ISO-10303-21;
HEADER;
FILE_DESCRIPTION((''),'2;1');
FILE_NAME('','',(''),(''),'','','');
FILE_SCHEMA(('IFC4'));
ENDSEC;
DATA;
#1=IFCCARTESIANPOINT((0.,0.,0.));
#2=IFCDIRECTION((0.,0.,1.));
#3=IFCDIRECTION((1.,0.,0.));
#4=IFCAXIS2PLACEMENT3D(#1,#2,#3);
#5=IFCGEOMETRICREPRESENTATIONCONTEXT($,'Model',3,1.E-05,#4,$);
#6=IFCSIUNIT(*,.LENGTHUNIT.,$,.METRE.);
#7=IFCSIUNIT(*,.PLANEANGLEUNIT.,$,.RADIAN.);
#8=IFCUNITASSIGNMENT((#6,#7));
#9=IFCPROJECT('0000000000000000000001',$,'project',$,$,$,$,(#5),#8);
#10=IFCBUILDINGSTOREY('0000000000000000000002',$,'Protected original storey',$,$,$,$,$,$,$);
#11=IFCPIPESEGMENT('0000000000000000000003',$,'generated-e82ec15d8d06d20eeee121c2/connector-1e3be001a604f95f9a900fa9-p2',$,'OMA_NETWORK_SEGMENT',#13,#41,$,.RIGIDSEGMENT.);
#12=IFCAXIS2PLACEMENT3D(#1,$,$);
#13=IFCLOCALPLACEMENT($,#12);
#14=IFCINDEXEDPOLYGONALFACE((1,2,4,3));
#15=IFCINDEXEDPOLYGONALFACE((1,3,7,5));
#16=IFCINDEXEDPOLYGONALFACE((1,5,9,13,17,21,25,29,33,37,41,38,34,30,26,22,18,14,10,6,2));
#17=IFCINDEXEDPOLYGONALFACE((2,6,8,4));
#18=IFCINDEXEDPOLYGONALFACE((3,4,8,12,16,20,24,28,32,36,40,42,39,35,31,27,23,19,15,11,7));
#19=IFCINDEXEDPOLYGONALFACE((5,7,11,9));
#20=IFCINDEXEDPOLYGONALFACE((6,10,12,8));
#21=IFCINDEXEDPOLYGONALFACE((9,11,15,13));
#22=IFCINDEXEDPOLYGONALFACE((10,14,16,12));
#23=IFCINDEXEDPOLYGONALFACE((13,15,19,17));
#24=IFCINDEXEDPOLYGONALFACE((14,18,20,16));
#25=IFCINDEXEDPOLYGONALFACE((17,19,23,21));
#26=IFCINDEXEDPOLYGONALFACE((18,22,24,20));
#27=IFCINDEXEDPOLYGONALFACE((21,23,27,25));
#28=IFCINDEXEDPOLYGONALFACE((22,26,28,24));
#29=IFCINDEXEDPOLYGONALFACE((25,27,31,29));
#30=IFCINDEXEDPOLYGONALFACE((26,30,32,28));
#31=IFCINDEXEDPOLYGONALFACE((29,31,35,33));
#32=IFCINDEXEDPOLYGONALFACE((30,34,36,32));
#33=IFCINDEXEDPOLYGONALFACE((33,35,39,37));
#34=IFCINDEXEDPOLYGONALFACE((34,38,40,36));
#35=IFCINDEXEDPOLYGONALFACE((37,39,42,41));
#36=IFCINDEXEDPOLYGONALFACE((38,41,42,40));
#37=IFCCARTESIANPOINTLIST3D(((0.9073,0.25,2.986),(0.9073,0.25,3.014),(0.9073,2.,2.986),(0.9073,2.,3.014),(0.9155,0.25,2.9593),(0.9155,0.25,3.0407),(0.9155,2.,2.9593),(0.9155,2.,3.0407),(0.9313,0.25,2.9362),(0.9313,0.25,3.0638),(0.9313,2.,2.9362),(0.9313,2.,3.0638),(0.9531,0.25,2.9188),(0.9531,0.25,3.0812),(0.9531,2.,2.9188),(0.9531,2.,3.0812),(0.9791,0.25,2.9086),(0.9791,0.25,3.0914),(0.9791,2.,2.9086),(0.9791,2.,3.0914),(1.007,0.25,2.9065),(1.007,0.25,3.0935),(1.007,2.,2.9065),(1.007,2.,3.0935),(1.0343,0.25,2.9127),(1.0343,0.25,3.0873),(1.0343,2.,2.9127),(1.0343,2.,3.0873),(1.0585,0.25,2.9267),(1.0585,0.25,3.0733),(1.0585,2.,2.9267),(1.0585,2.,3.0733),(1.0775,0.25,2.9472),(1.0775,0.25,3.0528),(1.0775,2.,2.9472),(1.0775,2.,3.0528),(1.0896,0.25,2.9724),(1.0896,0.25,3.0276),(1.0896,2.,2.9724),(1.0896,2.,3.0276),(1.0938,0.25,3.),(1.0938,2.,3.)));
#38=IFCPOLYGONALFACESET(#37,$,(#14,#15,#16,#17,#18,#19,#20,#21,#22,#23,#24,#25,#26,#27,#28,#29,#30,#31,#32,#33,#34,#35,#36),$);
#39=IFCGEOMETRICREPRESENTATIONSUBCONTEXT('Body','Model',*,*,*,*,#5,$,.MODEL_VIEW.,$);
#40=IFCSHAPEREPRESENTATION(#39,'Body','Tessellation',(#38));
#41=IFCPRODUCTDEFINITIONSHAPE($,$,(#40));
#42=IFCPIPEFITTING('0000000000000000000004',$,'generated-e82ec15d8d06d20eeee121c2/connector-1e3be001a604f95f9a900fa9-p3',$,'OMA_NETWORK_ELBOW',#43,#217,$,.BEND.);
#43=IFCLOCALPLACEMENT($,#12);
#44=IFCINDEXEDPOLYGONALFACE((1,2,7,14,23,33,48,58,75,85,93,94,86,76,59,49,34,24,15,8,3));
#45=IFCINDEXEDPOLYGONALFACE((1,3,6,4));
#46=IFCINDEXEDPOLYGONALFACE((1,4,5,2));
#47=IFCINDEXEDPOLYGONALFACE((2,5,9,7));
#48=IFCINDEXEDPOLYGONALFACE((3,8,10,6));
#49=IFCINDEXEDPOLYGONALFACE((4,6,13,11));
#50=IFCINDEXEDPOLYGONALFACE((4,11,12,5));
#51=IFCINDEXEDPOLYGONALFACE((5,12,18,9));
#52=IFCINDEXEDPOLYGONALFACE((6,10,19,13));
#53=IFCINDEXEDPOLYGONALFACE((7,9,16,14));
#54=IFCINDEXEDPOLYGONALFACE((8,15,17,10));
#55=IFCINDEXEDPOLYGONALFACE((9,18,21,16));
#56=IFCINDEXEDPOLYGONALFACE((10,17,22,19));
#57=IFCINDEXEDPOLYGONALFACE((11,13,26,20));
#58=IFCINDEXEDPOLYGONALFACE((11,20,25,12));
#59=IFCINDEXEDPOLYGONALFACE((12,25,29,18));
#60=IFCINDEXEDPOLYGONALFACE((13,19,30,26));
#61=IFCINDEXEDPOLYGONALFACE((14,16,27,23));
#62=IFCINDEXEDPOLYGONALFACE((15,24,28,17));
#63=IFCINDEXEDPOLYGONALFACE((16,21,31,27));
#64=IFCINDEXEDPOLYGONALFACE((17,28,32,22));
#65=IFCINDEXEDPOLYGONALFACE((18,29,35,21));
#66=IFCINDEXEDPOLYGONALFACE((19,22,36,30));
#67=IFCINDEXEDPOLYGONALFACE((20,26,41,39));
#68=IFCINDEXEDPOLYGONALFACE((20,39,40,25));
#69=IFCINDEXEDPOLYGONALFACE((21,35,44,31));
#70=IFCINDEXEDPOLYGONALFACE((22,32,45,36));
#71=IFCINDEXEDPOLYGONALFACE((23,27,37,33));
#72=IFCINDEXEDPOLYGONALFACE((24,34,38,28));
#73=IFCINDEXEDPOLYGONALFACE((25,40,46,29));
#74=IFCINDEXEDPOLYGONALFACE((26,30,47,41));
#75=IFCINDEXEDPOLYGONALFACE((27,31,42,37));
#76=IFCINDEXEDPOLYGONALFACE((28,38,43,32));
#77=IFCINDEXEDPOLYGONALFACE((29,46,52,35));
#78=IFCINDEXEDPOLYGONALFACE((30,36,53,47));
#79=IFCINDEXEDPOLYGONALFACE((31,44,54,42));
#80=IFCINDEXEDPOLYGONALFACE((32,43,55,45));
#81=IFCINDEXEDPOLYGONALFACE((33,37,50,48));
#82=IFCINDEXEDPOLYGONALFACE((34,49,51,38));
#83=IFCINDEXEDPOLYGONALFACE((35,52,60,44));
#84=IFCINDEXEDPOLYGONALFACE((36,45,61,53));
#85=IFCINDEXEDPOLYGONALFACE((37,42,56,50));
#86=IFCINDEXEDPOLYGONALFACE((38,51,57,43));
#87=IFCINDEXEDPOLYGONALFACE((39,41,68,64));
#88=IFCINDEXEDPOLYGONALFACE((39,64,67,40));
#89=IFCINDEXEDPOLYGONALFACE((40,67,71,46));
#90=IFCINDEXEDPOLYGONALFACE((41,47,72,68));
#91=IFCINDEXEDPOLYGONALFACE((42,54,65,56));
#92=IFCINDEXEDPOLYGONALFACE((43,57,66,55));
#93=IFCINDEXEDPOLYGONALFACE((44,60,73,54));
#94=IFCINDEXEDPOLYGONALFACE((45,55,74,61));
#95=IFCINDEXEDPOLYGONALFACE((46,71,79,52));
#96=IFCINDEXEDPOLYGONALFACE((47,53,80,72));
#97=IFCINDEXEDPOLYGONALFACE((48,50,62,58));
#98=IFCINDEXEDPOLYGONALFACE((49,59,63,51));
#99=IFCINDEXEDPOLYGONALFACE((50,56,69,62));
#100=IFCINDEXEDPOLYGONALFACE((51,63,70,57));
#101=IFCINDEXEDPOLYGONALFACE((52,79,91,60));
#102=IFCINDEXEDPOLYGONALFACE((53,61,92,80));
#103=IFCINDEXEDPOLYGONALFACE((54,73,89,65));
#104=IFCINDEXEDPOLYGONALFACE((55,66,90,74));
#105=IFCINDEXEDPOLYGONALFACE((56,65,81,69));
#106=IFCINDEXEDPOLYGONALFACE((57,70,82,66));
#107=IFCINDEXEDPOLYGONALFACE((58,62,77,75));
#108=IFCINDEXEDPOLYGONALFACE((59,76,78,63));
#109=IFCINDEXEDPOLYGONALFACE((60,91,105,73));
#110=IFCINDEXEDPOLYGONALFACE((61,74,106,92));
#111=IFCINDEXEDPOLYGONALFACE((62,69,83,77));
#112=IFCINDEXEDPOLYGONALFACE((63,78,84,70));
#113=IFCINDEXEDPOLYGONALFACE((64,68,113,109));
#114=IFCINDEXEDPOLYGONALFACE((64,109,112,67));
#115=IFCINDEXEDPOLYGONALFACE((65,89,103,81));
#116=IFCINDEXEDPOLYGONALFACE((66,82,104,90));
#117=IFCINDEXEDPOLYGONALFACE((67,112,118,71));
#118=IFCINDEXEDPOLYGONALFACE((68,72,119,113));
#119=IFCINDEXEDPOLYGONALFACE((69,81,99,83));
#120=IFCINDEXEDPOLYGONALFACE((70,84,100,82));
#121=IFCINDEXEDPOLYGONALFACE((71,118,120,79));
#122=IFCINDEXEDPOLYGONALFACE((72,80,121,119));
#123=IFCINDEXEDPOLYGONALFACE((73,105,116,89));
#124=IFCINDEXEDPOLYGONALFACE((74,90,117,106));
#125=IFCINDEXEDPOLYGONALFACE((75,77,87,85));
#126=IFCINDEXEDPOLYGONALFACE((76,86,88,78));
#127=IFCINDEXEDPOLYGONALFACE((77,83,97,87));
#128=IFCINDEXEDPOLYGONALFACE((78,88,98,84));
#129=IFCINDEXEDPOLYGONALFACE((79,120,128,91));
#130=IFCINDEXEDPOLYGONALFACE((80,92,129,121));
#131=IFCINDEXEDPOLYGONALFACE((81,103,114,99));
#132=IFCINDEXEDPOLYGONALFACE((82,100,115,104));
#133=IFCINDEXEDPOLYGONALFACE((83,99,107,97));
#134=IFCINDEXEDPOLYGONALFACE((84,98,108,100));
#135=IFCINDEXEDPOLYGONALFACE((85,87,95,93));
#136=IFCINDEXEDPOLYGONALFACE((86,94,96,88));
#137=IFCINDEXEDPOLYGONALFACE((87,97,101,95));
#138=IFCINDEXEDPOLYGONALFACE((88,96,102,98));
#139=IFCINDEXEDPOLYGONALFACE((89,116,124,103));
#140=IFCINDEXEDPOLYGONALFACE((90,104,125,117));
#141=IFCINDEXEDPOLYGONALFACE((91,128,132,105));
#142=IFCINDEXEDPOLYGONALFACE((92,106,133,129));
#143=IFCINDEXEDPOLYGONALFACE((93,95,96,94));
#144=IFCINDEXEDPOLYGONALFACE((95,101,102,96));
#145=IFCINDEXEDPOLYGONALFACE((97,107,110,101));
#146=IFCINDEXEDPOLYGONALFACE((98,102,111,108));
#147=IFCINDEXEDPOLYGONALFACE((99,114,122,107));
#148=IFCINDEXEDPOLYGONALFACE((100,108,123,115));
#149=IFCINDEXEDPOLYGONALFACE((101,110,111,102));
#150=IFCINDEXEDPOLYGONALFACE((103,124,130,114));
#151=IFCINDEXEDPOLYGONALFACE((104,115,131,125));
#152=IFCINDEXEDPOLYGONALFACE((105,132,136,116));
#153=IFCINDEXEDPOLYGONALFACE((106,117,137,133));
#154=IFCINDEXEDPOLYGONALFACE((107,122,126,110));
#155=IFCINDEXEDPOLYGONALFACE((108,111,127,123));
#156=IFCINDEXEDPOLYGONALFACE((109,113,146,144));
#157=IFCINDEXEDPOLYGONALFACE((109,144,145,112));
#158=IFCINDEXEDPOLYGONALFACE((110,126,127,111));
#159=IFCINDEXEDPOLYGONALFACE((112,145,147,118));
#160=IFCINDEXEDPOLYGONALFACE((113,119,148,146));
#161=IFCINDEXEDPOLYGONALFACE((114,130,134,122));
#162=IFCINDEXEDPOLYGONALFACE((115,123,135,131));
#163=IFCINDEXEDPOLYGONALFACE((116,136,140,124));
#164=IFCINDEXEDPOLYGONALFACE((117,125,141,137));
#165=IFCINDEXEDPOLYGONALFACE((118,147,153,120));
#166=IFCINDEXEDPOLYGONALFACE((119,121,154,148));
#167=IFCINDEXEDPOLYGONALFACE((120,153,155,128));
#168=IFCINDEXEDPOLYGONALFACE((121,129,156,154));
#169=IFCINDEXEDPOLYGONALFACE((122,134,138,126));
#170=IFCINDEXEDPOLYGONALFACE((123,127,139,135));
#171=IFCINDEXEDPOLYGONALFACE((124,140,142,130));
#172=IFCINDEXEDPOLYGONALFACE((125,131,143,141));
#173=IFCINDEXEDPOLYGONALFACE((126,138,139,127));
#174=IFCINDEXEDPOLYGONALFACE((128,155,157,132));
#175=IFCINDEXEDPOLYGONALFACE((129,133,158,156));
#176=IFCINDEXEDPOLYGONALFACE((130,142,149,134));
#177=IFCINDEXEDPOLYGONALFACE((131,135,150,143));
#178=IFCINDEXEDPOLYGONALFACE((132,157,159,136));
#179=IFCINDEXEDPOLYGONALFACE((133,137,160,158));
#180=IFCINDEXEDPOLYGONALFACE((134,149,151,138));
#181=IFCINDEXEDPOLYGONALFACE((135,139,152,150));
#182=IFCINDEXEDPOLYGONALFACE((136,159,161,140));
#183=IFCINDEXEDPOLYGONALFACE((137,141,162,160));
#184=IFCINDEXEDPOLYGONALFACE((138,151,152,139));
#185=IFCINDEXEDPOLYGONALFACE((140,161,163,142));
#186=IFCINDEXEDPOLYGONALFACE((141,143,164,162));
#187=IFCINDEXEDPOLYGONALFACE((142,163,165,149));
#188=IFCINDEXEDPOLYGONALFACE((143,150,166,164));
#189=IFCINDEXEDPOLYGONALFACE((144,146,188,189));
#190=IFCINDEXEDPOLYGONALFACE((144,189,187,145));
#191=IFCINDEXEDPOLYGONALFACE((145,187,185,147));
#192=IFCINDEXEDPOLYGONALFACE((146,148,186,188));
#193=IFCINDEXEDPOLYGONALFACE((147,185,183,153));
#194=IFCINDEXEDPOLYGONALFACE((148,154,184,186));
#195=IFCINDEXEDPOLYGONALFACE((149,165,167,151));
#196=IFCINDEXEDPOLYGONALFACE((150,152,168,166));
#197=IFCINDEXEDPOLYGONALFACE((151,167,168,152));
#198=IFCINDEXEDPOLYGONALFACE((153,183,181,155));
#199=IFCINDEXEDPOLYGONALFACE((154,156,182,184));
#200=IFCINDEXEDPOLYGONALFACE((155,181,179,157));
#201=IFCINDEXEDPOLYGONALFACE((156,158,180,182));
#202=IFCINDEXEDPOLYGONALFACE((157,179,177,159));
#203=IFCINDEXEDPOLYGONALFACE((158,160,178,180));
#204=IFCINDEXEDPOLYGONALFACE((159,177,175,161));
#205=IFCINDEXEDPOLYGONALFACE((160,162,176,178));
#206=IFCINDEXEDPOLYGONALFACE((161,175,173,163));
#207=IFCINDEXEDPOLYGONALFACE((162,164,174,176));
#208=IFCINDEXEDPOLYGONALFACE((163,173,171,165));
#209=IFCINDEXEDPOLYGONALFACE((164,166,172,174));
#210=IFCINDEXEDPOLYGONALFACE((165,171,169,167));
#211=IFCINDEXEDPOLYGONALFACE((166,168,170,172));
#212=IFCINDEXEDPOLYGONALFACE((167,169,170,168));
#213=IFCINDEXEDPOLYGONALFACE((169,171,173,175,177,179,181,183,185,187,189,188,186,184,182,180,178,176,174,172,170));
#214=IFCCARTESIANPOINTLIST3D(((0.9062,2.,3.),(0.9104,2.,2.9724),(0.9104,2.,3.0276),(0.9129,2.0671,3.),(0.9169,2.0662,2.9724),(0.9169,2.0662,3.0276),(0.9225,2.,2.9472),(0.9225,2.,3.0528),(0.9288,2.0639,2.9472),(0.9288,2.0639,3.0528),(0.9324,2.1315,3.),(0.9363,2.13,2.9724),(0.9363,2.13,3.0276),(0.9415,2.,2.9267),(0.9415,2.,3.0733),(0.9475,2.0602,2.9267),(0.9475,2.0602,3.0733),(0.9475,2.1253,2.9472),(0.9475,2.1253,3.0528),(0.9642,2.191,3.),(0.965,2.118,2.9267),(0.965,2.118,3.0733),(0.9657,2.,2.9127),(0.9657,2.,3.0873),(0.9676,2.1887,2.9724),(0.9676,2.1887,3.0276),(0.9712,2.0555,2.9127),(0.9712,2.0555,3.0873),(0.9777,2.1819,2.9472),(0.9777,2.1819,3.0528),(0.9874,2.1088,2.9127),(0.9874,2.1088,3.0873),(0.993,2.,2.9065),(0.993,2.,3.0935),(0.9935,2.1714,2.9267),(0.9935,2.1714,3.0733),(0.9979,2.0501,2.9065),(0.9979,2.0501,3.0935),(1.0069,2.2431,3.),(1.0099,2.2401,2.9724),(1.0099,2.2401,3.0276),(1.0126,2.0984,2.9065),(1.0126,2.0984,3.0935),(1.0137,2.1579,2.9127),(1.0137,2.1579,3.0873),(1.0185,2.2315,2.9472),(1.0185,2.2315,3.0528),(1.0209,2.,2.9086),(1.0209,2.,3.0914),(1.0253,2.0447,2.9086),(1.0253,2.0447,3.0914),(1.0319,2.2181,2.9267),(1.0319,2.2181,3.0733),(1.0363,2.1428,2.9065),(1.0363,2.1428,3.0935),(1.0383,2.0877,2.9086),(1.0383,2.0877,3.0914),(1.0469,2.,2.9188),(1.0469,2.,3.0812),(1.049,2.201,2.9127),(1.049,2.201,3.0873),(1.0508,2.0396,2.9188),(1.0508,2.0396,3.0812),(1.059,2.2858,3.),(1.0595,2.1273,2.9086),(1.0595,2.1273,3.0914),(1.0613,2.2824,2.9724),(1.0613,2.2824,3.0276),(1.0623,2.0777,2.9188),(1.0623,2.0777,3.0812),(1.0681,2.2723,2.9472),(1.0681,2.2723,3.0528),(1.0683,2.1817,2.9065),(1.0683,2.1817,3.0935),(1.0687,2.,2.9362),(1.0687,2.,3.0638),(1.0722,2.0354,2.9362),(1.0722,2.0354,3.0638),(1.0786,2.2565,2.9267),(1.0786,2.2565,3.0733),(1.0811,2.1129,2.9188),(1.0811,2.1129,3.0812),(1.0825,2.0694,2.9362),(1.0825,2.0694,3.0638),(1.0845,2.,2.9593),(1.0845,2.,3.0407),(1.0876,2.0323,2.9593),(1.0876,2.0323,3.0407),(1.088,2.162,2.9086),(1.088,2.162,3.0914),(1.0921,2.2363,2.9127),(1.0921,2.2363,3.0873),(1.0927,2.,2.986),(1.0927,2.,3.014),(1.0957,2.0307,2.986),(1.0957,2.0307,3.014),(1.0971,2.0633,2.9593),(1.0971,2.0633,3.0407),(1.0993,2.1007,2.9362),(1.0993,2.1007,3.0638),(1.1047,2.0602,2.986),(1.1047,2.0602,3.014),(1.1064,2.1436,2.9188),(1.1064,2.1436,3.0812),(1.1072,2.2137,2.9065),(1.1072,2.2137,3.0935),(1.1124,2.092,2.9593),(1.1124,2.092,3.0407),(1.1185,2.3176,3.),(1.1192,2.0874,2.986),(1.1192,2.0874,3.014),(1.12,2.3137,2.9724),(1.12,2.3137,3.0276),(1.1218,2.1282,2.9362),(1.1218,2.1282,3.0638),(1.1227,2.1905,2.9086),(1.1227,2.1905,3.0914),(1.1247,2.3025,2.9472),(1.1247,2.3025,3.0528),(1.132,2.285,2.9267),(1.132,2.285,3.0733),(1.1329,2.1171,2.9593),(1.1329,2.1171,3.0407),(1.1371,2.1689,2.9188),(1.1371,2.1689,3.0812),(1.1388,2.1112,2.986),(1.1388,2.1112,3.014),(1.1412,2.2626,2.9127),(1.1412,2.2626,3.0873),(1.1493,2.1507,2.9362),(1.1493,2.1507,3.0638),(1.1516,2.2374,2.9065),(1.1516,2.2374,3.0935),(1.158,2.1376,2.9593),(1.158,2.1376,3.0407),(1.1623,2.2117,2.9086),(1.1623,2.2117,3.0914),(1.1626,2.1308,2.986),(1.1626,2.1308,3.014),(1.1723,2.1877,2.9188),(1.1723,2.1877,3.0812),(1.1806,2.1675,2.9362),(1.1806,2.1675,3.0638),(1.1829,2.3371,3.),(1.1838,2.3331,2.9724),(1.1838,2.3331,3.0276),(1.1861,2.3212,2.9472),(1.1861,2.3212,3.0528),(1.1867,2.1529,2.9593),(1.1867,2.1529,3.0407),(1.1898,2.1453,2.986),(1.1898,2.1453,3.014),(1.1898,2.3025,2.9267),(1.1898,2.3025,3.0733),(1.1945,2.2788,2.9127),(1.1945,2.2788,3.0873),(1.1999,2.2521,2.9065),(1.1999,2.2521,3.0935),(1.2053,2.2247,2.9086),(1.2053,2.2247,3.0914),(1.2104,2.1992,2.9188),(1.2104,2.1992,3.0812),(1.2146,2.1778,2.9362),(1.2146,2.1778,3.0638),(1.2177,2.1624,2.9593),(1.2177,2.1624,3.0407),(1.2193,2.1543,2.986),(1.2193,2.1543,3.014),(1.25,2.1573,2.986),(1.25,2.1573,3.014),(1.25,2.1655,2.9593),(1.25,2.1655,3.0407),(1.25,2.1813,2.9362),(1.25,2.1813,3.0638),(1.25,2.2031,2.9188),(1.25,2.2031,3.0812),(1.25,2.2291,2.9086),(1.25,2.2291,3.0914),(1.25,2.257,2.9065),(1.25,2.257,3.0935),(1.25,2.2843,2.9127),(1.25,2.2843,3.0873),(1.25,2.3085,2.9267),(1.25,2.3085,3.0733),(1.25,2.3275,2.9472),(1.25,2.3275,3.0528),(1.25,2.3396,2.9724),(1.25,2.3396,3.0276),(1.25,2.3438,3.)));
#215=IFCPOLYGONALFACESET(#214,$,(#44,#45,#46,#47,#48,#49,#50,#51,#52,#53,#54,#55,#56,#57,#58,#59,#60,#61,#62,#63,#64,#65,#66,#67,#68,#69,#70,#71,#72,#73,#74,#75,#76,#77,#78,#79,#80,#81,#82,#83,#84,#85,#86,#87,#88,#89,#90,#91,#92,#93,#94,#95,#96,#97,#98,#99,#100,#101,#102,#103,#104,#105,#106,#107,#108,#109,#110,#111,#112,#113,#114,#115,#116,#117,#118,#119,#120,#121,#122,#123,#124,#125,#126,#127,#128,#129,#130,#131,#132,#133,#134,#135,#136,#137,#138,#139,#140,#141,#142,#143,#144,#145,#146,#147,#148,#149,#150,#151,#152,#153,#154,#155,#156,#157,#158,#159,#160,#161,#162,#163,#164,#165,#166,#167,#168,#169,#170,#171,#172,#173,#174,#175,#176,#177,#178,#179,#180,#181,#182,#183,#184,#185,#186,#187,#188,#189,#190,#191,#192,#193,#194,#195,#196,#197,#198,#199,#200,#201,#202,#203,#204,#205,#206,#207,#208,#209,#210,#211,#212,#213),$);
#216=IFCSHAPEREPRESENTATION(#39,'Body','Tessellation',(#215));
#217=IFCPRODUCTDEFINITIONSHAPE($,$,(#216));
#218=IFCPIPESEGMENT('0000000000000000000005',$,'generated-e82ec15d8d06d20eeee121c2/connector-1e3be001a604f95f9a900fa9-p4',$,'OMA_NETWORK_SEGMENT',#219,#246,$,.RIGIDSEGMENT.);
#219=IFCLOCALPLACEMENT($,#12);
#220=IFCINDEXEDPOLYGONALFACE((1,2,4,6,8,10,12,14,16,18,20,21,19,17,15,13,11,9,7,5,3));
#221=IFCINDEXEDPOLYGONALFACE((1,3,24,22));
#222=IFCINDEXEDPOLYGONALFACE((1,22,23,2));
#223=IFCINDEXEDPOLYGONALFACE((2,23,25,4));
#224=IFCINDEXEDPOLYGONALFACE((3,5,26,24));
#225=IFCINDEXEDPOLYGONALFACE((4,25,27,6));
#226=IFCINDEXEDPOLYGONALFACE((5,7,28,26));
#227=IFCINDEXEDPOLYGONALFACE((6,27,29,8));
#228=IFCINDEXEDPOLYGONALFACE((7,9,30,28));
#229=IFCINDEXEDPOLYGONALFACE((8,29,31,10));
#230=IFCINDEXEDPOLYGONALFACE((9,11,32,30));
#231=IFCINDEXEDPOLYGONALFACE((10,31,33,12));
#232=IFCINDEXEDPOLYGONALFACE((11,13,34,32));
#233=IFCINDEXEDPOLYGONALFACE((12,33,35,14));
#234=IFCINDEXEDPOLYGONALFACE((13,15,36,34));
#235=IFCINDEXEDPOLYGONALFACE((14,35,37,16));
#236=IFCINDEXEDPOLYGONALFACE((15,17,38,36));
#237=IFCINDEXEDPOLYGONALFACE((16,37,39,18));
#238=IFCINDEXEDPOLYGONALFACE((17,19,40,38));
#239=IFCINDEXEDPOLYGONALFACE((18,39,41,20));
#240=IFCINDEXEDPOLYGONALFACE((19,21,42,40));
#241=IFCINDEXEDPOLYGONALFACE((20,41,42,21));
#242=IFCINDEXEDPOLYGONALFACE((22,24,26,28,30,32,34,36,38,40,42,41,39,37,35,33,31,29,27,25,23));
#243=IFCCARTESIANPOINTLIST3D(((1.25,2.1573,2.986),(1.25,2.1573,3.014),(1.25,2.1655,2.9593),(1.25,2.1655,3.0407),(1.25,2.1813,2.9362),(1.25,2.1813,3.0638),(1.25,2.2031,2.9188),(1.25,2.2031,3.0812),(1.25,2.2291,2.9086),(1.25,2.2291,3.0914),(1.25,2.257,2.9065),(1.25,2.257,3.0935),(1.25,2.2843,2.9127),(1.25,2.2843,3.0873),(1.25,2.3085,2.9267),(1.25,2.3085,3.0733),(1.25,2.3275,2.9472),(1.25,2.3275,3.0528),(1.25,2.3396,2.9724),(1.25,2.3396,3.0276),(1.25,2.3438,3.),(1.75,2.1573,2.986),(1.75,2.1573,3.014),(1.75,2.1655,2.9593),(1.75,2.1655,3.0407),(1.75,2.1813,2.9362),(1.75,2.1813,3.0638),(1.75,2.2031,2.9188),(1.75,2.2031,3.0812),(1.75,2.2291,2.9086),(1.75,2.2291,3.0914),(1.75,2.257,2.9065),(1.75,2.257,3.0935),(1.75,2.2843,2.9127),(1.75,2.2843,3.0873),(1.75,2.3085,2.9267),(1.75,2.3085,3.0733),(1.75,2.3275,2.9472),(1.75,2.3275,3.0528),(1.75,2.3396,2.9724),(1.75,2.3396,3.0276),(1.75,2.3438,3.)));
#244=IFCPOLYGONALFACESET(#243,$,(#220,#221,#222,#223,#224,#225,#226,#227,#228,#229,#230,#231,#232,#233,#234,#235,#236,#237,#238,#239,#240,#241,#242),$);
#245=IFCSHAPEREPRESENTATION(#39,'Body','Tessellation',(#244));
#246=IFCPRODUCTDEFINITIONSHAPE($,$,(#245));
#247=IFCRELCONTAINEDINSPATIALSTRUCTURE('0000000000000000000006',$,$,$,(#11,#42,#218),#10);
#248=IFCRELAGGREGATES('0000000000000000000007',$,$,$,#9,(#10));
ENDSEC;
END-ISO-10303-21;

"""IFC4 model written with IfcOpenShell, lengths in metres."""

from ifc_helpers import new_model, entity, si_unit, frame, origin_with_axes, origin_2d, place, context, subcontext, project, spatial, circle, extrude, element, save


model = new_model("IFC4")

# Units and contexts
model_context = context("Model", 3, precision=1e-05, world=origin_with_axes())
body_context = subcontext(model_context, "Body", "Model", "MODEL_VIEW")
ifc_project = project(units=[si_unit("LENGTHUNIT", "METRE"), si_unit("PLANEANGLEUNIT", "RADIAN")], contexts=[model_context])

# Storey
storey = spatial("IfcBuildingStorey", under=ifc_project, Name="Protected original storey")

# Pipe segment
pipe_segment_1_placement = place(None, origin_with_axes())
element("IfcPipeSegment", 1, at=pipe_segment_1_placement, inside=storey, Name="generated-e82ec15d8d06d20eeee121c2/connector-1e3be001a604f95f9a900fa9-p2", ObjectType="OMA_NETWORK_SEGMENT", PredefinedType="RIGIDSEGMENT", context=body_context, shape_type="SweptSolid", body=[
    extrude(circle(Radius=0.0938, at=origin_2d()), frame((1.0, 0.25, 3.0), z_axis=(0.0, 1.0, 0.0), x_axis=(1.0, 0.0, 0.0)), (0.0, 0.0, 1.0), 1.75),
])

# Pipe fitting
pipe_fitting_1_placement = place(None, origin_with_axes())
element("IfcPipeFitting", 2, at=pipe_fitting_1_placement, inside=storey, Name="generated-e82ec15d8d06d20eeee121c2/connector-1e3be001a604f95f9a900fa9-p3", ObjectType="OMA_NETWORK_ELBOW", PredefinedType="BEND", context=body_context, shape_type="SweptSolid", body=[
    entity("IfcRevolvedAreaSolid", entity("IfcCircleProfileDef", "AREA", None, entity("IfcAxis2Placement2D", entity("IfcCartesianPoint", [0.25, 0.0])), 0.0938), entity("IfcAxis2Placement3D", entity("IfcCartesianPoint", [1.25, 2.0, 3.0]), entity("IfcDirection", [0.0, 1.0, 0.0]), entity("IfcDirection", [-1.0, 0.0, 0.0])), entity("IfcAxis1Placement", entity("IfcCartesianPoint", [0.0, 0.0, 0.0]), entity("IfcDirection", [0.0, -1.0, 0.0])), 1.570796),
])

# Pipe segment
pipe_segment_2_placement = place(None, origin_with_axes())
element("IfcPipeSegment", 3, at=pipe_segment_2_placement, inside=storey, Name="generated-e82ec15d8d06d20eeee121c2/connector-1e3be001a604f95f9a900fa9-p4", ObjectType="OMA_NETWORK_SEGMENT", PredefinedType="RIGIDSEGMENT", context=body_context, shape_type="SweptSolid", body=[
    extrude(circle(Radius=0.0938, at=origin_2d()), frame((1.25, 2.25, 3.0), z_axis=(1.0, 0.0, 0.0), x_axis=(0.0, 1.0, 0.0)), (0.0, 0.0, 1.0), 0.5),
])

save(model, "model.ifc")
